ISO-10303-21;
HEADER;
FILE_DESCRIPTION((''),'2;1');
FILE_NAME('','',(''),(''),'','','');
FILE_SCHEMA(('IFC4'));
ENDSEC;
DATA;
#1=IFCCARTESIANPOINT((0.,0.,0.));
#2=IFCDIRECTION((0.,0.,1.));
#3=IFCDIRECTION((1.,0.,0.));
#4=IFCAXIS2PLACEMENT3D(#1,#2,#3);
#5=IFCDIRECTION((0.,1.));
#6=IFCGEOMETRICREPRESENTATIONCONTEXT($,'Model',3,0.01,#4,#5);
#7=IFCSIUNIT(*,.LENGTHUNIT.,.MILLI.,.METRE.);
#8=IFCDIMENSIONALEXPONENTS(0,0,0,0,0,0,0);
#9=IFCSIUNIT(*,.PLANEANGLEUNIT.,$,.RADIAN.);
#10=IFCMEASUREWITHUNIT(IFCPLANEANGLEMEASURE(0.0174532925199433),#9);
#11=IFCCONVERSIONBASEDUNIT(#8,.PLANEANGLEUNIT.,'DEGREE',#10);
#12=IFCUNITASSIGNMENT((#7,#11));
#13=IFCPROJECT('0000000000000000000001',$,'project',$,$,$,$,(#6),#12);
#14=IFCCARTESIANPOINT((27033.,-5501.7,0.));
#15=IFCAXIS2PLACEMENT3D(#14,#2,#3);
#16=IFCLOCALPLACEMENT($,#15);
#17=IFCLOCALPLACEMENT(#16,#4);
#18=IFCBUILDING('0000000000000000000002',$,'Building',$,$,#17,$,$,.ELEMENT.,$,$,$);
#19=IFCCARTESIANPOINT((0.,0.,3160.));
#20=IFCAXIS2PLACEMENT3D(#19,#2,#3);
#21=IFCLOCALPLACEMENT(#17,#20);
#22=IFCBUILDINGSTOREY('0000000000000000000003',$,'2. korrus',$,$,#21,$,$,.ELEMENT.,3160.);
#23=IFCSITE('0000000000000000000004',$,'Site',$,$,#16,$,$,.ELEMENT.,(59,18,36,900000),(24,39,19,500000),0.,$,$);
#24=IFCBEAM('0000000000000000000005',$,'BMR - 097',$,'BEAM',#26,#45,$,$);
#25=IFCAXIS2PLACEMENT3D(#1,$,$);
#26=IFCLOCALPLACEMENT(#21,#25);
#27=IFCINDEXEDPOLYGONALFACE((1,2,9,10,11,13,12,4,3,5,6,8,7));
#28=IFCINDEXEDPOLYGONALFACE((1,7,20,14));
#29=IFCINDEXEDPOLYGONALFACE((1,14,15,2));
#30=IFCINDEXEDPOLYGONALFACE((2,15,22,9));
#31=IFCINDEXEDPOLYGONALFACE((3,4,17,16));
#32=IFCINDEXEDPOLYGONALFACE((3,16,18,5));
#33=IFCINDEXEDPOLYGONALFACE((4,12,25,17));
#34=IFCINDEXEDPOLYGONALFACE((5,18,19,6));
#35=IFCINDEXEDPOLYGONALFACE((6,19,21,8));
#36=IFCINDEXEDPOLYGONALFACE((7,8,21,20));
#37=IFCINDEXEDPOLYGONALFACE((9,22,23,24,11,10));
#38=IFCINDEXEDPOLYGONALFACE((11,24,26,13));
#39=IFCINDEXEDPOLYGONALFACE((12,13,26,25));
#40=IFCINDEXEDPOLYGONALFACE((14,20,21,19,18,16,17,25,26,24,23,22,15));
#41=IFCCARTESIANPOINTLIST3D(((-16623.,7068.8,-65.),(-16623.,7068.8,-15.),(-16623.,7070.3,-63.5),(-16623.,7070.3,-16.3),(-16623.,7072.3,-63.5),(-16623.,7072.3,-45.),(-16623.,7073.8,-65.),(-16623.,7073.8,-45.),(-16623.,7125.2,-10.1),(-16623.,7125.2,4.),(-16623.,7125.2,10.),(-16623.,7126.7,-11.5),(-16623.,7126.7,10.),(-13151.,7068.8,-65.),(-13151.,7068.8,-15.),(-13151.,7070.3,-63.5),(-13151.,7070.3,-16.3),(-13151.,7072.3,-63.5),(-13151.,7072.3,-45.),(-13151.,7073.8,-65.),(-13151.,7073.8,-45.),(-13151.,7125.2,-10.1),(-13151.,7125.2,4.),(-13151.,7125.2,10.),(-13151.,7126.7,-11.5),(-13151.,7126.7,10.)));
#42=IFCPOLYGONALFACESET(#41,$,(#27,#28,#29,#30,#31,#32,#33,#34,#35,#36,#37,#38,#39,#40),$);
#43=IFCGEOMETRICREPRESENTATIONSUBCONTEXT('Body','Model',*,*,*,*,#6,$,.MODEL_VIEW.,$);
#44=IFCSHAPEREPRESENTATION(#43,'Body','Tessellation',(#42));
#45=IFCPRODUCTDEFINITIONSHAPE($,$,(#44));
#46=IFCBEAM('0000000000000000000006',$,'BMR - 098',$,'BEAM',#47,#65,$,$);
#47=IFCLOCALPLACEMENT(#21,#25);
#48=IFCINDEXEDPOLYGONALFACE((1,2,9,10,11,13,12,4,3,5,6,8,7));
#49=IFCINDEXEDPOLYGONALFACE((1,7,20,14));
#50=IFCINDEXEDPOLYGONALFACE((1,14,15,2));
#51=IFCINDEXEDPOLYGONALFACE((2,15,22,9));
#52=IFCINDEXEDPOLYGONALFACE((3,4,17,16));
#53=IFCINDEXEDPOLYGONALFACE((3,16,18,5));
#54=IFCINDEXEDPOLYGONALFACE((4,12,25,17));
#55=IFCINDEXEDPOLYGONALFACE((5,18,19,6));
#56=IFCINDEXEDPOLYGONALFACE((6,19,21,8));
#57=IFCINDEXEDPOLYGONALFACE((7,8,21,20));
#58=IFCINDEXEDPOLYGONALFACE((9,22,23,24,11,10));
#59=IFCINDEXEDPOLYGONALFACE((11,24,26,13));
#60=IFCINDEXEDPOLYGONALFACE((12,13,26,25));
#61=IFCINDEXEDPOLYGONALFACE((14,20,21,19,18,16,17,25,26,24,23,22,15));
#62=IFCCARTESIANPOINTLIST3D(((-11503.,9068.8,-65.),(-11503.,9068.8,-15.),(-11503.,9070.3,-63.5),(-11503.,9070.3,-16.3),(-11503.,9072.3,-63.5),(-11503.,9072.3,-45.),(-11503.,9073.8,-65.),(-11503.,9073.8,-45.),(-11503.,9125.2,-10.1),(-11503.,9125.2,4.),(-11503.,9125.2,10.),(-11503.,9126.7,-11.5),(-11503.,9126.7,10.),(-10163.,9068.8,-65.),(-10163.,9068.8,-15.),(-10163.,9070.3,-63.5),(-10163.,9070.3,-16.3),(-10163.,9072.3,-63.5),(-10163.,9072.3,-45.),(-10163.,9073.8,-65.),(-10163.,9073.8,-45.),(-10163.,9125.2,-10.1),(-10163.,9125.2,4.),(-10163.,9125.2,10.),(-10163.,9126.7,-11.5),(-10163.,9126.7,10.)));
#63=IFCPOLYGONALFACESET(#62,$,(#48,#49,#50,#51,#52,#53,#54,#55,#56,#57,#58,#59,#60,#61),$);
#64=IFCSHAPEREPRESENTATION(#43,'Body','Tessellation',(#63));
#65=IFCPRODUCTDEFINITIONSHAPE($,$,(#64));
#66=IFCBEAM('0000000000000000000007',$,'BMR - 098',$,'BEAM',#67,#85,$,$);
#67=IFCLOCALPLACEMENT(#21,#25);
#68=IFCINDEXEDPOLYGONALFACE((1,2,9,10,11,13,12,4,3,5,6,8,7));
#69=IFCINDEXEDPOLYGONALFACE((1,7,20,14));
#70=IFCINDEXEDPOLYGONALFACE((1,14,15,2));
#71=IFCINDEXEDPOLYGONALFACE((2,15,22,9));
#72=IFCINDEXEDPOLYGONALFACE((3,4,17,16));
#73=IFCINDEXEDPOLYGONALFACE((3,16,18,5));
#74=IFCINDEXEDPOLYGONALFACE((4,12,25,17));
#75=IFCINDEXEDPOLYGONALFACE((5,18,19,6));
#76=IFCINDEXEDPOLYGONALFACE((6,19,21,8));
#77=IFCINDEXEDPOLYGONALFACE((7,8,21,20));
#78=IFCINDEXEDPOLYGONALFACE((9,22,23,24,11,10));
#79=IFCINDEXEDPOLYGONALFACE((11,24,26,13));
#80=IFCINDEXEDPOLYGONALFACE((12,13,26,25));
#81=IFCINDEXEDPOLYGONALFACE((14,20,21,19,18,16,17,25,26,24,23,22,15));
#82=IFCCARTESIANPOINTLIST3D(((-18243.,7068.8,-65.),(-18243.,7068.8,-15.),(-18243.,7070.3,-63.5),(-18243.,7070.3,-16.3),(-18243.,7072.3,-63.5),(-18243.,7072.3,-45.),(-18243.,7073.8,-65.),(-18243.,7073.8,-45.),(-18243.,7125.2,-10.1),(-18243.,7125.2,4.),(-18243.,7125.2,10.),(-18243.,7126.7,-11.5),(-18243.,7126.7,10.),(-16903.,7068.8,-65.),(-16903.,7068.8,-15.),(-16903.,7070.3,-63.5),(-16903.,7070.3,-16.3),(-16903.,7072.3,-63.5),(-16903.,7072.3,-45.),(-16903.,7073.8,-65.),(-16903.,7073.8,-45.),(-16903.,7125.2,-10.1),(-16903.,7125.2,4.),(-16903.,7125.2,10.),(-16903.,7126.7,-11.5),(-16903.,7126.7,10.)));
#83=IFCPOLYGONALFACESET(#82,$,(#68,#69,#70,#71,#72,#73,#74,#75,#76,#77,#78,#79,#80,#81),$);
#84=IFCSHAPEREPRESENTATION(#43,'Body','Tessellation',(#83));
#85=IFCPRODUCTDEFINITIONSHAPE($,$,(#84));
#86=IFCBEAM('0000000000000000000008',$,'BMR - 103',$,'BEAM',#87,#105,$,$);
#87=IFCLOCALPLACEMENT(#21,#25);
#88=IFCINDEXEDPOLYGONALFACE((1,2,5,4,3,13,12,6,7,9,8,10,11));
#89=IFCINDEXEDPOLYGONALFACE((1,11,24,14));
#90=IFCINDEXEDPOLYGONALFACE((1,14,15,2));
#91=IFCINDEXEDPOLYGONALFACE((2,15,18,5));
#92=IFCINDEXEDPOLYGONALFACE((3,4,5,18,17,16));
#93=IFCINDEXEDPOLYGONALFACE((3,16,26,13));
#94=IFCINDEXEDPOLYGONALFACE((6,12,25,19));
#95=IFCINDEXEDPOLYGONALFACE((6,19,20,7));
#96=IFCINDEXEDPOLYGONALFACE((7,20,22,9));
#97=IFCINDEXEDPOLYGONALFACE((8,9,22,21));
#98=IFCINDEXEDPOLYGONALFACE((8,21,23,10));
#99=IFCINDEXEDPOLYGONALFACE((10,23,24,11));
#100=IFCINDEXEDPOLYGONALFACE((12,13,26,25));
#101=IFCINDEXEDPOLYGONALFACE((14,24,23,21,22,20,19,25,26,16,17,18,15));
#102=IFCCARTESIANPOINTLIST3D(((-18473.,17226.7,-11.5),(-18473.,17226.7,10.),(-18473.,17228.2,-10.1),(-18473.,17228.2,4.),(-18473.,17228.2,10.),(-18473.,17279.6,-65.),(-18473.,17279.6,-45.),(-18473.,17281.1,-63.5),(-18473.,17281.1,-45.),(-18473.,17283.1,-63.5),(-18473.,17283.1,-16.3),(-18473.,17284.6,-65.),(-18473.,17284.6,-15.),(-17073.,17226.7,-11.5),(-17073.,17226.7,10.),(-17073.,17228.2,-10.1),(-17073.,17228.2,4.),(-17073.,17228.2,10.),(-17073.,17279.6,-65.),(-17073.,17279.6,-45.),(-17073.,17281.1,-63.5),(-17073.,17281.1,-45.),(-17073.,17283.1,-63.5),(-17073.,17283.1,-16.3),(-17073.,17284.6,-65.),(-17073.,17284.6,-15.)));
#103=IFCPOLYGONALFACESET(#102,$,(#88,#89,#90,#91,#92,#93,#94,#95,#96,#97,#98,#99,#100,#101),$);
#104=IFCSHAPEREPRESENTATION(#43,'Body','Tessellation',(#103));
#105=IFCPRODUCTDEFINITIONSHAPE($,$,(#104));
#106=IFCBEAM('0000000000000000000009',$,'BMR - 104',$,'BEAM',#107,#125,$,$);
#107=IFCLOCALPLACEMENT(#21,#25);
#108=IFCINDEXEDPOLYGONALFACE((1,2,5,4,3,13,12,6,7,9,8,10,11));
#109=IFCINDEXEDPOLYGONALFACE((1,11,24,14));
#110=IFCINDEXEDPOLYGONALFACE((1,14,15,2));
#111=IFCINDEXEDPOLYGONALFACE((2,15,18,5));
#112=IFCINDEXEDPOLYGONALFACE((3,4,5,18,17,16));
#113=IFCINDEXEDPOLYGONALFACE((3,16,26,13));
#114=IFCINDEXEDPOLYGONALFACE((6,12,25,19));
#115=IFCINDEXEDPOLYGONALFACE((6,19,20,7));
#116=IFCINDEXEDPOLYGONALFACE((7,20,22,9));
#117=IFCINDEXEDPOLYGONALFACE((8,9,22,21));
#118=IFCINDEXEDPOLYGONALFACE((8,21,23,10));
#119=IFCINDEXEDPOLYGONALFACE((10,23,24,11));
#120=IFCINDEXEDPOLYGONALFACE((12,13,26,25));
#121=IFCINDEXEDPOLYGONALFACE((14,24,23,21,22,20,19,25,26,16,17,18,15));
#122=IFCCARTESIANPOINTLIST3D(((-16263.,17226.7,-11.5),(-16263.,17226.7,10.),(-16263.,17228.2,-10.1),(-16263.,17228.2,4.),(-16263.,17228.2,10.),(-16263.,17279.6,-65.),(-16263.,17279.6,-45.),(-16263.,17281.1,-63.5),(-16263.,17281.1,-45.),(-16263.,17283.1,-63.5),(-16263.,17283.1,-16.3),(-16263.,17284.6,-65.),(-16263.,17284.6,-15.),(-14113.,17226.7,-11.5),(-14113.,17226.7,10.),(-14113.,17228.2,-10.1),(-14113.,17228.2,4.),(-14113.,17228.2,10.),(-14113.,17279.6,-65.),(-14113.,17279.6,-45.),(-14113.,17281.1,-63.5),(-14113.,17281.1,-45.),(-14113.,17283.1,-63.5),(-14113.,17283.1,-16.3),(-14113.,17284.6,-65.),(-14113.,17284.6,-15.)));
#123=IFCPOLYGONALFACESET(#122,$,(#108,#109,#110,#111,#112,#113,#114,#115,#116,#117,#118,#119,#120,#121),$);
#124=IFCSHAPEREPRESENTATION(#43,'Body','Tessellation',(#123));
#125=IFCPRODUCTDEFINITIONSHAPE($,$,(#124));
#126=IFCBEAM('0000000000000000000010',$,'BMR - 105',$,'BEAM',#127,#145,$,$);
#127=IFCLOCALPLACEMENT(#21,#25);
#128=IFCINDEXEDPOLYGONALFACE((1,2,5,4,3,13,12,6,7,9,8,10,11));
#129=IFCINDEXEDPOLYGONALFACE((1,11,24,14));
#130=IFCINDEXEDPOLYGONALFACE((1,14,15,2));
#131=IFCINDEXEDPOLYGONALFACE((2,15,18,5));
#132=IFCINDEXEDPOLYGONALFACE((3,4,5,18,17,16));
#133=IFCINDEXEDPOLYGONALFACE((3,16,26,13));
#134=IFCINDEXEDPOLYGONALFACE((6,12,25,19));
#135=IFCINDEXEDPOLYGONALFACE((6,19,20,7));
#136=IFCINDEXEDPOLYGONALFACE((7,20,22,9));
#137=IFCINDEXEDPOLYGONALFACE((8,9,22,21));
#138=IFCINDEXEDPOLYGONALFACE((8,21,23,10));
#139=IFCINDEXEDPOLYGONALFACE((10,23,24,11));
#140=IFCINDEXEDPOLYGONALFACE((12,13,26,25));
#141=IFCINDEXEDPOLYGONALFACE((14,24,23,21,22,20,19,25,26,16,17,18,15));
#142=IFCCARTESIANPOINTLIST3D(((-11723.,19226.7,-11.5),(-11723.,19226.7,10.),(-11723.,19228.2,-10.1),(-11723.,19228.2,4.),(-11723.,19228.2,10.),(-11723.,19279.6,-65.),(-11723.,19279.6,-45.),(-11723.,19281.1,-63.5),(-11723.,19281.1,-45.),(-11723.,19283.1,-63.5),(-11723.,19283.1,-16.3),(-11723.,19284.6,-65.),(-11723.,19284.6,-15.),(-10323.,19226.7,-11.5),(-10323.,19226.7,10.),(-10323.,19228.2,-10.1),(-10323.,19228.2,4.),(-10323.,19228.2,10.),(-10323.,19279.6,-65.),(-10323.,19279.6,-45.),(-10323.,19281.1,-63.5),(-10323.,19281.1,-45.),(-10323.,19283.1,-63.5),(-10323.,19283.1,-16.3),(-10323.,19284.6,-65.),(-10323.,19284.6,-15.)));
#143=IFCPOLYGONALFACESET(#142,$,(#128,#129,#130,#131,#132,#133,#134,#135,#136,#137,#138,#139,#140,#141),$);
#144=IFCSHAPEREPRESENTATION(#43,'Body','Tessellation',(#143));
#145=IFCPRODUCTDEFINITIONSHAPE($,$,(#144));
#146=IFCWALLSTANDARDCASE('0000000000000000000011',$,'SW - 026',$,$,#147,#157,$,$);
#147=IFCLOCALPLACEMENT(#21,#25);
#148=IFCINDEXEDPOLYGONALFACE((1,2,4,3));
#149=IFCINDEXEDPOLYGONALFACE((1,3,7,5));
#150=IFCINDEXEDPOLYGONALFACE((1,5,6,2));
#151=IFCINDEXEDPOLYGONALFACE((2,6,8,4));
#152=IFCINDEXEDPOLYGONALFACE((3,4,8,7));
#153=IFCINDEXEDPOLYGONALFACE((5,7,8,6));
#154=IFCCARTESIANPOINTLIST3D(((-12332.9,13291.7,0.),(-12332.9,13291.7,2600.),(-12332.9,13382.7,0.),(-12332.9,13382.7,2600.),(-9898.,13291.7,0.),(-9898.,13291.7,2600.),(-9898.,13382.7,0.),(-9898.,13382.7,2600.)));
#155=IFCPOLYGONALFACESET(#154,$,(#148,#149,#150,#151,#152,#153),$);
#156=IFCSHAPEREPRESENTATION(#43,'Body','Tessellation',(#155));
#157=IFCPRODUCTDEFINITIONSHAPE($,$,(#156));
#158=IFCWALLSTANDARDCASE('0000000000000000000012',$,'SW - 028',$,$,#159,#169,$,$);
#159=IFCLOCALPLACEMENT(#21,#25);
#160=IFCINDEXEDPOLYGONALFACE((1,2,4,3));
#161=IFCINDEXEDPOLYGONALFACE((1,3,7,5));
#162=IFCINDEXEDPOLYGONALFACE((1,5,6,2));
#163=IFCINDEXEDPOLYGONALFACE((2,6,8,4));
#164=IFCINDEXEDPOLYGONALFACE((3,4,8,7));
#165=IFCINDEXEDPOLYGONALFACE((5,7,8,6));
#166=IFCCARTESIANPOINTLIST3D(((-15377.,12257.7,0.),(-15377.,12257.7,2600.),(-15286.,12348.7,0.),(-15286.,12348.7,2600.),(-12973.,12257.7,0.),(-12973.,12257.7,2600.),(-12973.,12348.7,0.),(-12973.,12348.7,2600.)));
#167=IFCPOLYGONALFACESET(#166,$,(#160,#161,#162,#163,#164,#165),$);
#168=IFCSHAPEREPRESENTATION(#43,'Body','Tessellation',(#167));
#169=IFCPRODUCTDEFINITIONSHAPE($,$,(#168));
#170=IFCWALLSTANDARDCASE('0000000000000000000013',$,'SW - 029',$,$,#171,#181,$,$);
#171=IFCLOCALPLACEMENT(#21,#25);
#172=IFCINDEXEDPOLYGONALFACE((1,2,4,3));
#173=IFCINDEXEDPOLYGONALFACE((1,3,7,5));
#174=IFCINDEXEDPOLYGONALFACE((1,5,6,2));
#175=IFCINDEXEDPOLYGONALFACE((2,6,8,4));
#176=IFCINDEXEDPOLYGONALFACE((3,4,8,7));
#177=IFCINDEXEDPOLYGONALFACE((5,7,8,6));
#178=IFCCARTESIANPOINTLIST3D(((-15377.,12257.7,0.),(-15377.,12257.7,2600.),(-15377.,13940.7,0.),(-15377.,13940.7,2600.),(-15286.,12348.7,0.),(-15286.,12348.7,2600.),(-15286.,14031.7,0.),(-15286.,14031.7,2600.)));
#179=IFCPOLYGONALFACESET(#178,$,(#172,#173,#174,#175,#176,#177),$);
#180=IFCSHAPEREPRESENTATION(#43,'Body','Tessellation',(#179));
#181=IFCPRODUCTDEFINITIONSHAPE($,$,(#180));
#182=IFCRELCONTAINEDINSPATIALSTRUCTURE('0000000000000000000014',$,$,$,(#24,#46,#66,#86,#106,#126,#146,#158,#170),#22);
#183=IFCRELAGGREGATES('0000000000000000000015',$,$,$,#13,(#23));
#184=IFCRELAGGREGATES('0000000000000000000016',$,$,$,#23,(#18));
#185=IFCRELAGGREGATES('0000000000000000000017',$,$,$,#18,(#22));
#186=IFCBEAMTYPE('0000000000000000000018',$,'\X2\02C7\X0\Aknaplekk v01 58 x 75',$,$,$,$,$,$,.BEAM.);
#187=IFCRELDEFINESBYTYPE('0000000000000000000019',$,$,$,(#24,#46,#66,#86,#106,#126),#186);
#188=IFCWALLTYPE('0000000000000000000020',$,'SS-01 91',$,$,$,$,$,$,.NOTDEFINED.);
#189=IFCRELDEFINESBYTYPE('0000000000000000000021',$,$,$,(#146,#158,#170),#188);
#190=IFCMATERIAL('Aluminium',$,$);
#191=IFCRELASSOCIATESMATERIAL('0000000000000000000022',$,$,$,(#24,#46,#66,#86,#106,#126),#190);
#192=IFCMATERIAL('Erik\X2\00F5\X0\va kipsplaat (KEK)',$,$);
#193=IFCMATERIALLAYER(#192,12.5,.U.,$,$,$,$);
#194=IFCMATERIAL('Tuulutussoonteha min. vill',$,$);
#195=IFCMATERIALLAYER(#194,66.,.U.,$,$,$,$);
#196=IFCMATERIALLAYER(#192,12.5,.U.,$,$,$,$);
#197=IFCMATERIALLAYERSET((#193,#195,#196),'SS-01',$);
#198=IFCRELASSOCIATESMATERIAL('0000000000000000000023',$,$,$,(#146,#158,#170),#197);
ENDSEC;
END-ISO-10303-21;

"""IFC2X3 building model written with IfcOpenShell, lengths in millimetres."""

from ifc_helpers import new_model, entity, si_unit, converted_unit, direction, frame, origin_with_axes, place, context, subcontext, project, spatial, polyline, outline, extrude, material, layer, layer_set, layer_usage, type_object, element, save


model = new_model("IFC2X3")

# Units and contexts
model_context = context("Model", 3, precision=0.01, world=origin_with_axes(), true_north=direction((0.0, 1.0)))
body_context = subcontext(model_context, "Body", "Model", "MODEL_VIEW")
ifc_project = project(units=[si_unit("LENGTHUNIT", "METRE", prefix="MILLI"), converted_unit("PLANEANGLEUNIT", "DEGREE", entity("IfcPlaneAngleMeasure", 0.0174532925199433), si_unit("PLANEANGLEUNIT", "RADIAN"), dimensions=[0, 0, 0, 0, 0, 0, 0])], contexts=[model_context])

# Site, building, storey
site_placement = place(None, frame((27033.0, -5501.7, 0.0), z_axis=(0.0, 0.0, 1.0), x_axis=(1.0, 0.0, 0.0)))
site = spatial("IfcSite", under=ifc_project, at=site_placement, Name="Site", CompositionType="ELEMENT", RefLatitude=(59, 18, 36, 900000), RefLongitude=(24, 39, 19, 500000), RefElevation=0.0)
building_placement = place(site_placement, origin_with_axes())
building = spatial("IfcBuilding", under=site, at=building_placement, Name="Building", CompositionType="ELEMENT")
storey_placement = place(building_placement, frame((0.0, 0.0, 3160.0), z_axis=(0.0, 0.0, 1.0), x_axis=(1.0, 0.0, 0.0)))
storey = spatial("IfcBuildingStorey", under=building, at=storey_placement, Name="2. korrus", CompositionType="ELEMENT", Elevation=3160.0)

# Beams
ifc_material_1 = material(Name="Aluminium")
beam_type = type_object("IfcBeamType", Name="ˇAknaplekk v01 58 x 75", PredefinedType="BEAM")
beam_1_placement = place(storey_placement, frame((-13151.0, 7126.7, 0.0), z_axis=(0.0, 0.0, 1.0), x_axis=(0.0, 1.0, 0.0)))
element("IfcBeam", 1, at=beam_1_placement, inside=storey, type_object=beam_type, material=ifc_material_1, Name="BMR - 097", ObjectType="BEAM", context=body_context, shape_type="SweptSolid", body=[
    extrude(outline(polyline([(-57.9, -15.0), (-57.9, -65.0), (-52.9, -65.0), (-52.9, -45.0), (-54.4, -45.0), (-54.4, -63.5), (-56.4, -63.5), (-56.4, -16.3), (0.0, -11.5), (0.0, 10.0), (-1.5, 10.0), (-1.5, 4.0), (-1.5, -10.1), (-57.9, -15.0)])), frame((0.0, 3472.0, 0.0), z_axis=(0.0, -1.0, 0.0), x_axis=(1.0, 0.0, 0.0)), (0.0, 0.0, 1.0), 3472.0),
])
beam_2_placement = place(storey_placement, frame((-10163.0, 9126.7, 0.0), z_axis=(0.0, 0.0, 1.0), x_axis=(0.0, 1.0, 0.0)))
element("IfcBeam", 2, at=beam_2_placement, inside=storey, type_object=beam_type, material=ifc_material_1, Name="BMR - 098", ObjectType="BEAM", context=body_context, shape_type="SweptSolid", body=[
    extrude(outline(polyline([(-57.9, -15.0), (-57.9, -65.0), (-52.9, -65.0), (-52.9, -45.0), (-54.4, -45.0), (-54.4, -63.5), (-56.4, -63.5), (-56.4, -16.3), (0.0, -11.5), (0.0, 10.0), (-1.5, 10.0), (-1.5, 4.0), (-1.5, -10.1), (-57.9, -15.0)])), frame((0.0, 1340.0, 0.0), z_axis=(0.0, -1.0, 0.0), x_axis=(1.0, 0.0, 0.0)), (0.0, 0.0, 1.0), 1340.0),
])
beam_3_placement = place(storey_placement, frame((-16903.0, 7126.7, 0.0), z_axis=(0.0, 0.0, 1.0), x_axis=(0.0, 1.0, 0.0)))
element("IfcBeam", 3, at=beam_3_placement, inside=storey, type_object=beam_type, material=ifc_material_1, Name="BMR - 098", ObjectType="BEAM", context=body_context, shape_type="SweptSolid", body=[
    extrude(outline(polyline([(-57.9, -15.0), (-57.9, -65.0), (-52.9, -65.0), (-52.9, -45.0), (-54.4, -45.0), (-54.4, -63.5), (-56.4, -63.5), (-56.4, -16.3), (0.0, -11.5), (0.0, 10.0), (-1.5, 10.0), (-1.5, 4.0), (-1.5, -10.1), (-57.9, -15.0)])), frame((0.0, 1340.0, 0.0), z_axis=(0.0, -1.0, 0.0), x_axis=(1.0, 0.0, 0.0)), (0.0, 0.0, 1.0), 1340.0),
])
beam_4_placement = place(storey_placement, frame((-18473.0, 17226.7, 0.0), z_axis=(0.0, 0.0, 1.0), x_axis=(0.0, -1.0, 0.0)))
element("IfcBeam", 4, at=beam_4_placement, inside=storey, type_object=beam_type, material=ifc_material_1, Name="BMR - 103", ObjectType="BEAM", context=body_context, shape_type="SweptSolid", body=[
    extrude(outline(polyline([(-57.9, -15.0), (-57.9, -65.0), (-52.9, -65.0), (-52.9, -45.0), (-54.4, -45.0), (-54.4, -63.5), (-56.4, -63.5), (-56.4, -16.3), (0.0, -11.5), (0.0, 10.0), (-1.5, 10.0), (-1.5, 4.0), (-1.5, -10.1), (-57.9, -15.0)])), frame((0.0, 1400.0, 0.0), z_axis=(0.0, -1.0, 0.0), x_axis=(1.0, 0.0, 0.0)), (0.0, 0.0, 1.0), 1400.0),
])
beam_5_placement = place(storey_placement, frame((-16263.0, 17226.7, 0.0), z_axis=(0.0, 0.0, 1.0), x_axis=(0.0, -1.0, 0.0)))
element("IfcBeam", 5, at=beam_5_placement, inside=storey, type_object=beam_type, material=ifc_material_1, Name="BMR - 104", ObjectType="BEAM", context=body_context, shape_type="SweptSolid", body=[
    extrude(outline(polyline([(-57.9, -15.0), (-57.9, -65.0), (-52.9, -65.0), (-52.9, -45.0), (-54.4, -45.0), (-54.4, -63.5), (-56.4, -63.5), (-56.4, -16.3), (0.0, -11.5), (0.0, 10.0), (-1.5, 10.0), (-1.5, 4.0), (-1.5, -10.1), (-57.9, -15.0)])), frame((0.0, 2150.0, 0.0), z_axis=(0.0, -1.0, 0.0), x_axis=(1.0, 0.0, 0.0)), (0.0, 0.0, 1.0), 2150.0),
])
beam_6_placement = place(storey_placement, frame((-11723.0, 19226.7, 0.0), z_axis=(0.0, 0.0, 1.0), x_axis=(0.0, -1.0, 0.0)))
element("IfcBeam", 6, at=beam_6_placement, inside=storey, type_object=beam_type, material=ifc_material_1, Name="BMR - 105", ObjectType="BEAM", context=body_context, shape_type="SweptSolid", body=[
    extrude(outline(polyline([(-57.9, -15.0), (-57.9, -65.0), (-52.9, -65.0), (-52.9, -45.0), (-54.4, -45.0), (-54.4, -63.5), (-56.4, -63.5), (-56.4, -16.3), (0.0, -11.5), (0.0, 10.0), (-1.5, 10.0), (-1.5, 4.0), (-1.5, -10.1), (-57.9, -15.0)])), frame((0.0, 1400.0, 0.0), z_axis=(0.0, -1.0, 0.0), x_axis=(1.0, 0.0, 0.0)), (0.0, 0.0, 1.0), 1400.0),
])

# Wall
ifc_material_2 = material(Name="Erikõva kipsplaat (KEK)")
ifc_layer_1 = layer(ifc_material_2, 12.5, ventilated="UNKNOWN")
ifc_material_3 = material(Name="Tuulutussoonteha min. vill")
ifc_layer_2 = layer(ifc_material_3, 66.0, ventilated="UNKNOWN")
ifc_layer_3 = layer(ifc_material_2, 12.5, ventilated="UNKNOWN")
ifc_layer_set_1 = layer_set([ifc_layer_1, ifc_layer_2, ifc_layer_3], Name="SS-01")
ifc_layer_usage_1 = layer_usage(ifc_layer_set_1, "AXIS2", "NEGATIVE", 91.0)
wall_type_1 = type_object("IfcWallType", Name="SS-01 91", PredefinedType="NOTDEFINED")
wall_1_placement = place(storey_placement, frame((-12332.9, 13291.7, 0.0), z_axis=(0.0, 0.0, 1.0), x_axis=(1.0, 0.0, 0.0)))
element("IfcWallStandardCase", 7, at=wall_1_placement, inside=storey, type_object=wall_type_1, material=ifc_layer_usage_1, Name="SW - 026", context=body_context, shape_type="SweptSolid", body=[
    extrude(outline(polyline([(0.0, 0.0), (2435.0, 0.0), (2435.0, 91.0), (0.0, 91.0), (0.0, 0.0)])), origin_with_axes(), (0.0, 0.0, 1.0), 2600.0),
])

# Walls
ifc_layer_usage_2 = layer_usage(ifc_layer_set_1, "AXIS2", "POSITIVE", -91.0)
wall_2_placement = place(storey_placement, frame((-12973.0, 12257.7, 0.0), z_axis=(0.0, 0.0, 1.0), x_axis=(-1.0, 0.0, 0.0)))
element("IfcWallStandardCase", 8, at=wall_2_placement, inside=storey, type_object=wall_type_1, material=ifc_layer_usage_2, Name="SW - 028", context=body_context, shape_type="SweptSolid", body=[
    extrude(outline(polyline([(0.0, -91.0), (2313.0, -91.0), (2404.0, 0.0), (0.0, 0.0), (0.0, -91.0)])), origin_with_axes(), (0.0, 0.0, 1.0), 2600.0),
])
ifc_layer_usage_3 = layer_usage(ifc_layer_set_1, "AXIS2", "POSITIVE", -91.0)
wall_3_placement = place(storey_placement, frame((-15377.0, 12257.7, 0.0), z_axis=(0.0, 0.0, 1.0), x_axis=(0.0, 1.0, 0.0)))
element("IfcWallStandardCase", 9, at=wall_3_placement, inside=storey, type_object=wall_type_1, material=ifc_layer_usage_3, Name="SW - 029", context=body_context, shape_type="SweptSolid", body=[
    extrude(outline(polyline([(91.0, -91.0), (1774.0, -91.0), (1683.0, 0.0), (0.0, 0.0), (91.0, -91.0)])), origin_with_axes(), (0.0, 0.0, 1.0), 2600.0),
])

save(model, "model.ifc")
